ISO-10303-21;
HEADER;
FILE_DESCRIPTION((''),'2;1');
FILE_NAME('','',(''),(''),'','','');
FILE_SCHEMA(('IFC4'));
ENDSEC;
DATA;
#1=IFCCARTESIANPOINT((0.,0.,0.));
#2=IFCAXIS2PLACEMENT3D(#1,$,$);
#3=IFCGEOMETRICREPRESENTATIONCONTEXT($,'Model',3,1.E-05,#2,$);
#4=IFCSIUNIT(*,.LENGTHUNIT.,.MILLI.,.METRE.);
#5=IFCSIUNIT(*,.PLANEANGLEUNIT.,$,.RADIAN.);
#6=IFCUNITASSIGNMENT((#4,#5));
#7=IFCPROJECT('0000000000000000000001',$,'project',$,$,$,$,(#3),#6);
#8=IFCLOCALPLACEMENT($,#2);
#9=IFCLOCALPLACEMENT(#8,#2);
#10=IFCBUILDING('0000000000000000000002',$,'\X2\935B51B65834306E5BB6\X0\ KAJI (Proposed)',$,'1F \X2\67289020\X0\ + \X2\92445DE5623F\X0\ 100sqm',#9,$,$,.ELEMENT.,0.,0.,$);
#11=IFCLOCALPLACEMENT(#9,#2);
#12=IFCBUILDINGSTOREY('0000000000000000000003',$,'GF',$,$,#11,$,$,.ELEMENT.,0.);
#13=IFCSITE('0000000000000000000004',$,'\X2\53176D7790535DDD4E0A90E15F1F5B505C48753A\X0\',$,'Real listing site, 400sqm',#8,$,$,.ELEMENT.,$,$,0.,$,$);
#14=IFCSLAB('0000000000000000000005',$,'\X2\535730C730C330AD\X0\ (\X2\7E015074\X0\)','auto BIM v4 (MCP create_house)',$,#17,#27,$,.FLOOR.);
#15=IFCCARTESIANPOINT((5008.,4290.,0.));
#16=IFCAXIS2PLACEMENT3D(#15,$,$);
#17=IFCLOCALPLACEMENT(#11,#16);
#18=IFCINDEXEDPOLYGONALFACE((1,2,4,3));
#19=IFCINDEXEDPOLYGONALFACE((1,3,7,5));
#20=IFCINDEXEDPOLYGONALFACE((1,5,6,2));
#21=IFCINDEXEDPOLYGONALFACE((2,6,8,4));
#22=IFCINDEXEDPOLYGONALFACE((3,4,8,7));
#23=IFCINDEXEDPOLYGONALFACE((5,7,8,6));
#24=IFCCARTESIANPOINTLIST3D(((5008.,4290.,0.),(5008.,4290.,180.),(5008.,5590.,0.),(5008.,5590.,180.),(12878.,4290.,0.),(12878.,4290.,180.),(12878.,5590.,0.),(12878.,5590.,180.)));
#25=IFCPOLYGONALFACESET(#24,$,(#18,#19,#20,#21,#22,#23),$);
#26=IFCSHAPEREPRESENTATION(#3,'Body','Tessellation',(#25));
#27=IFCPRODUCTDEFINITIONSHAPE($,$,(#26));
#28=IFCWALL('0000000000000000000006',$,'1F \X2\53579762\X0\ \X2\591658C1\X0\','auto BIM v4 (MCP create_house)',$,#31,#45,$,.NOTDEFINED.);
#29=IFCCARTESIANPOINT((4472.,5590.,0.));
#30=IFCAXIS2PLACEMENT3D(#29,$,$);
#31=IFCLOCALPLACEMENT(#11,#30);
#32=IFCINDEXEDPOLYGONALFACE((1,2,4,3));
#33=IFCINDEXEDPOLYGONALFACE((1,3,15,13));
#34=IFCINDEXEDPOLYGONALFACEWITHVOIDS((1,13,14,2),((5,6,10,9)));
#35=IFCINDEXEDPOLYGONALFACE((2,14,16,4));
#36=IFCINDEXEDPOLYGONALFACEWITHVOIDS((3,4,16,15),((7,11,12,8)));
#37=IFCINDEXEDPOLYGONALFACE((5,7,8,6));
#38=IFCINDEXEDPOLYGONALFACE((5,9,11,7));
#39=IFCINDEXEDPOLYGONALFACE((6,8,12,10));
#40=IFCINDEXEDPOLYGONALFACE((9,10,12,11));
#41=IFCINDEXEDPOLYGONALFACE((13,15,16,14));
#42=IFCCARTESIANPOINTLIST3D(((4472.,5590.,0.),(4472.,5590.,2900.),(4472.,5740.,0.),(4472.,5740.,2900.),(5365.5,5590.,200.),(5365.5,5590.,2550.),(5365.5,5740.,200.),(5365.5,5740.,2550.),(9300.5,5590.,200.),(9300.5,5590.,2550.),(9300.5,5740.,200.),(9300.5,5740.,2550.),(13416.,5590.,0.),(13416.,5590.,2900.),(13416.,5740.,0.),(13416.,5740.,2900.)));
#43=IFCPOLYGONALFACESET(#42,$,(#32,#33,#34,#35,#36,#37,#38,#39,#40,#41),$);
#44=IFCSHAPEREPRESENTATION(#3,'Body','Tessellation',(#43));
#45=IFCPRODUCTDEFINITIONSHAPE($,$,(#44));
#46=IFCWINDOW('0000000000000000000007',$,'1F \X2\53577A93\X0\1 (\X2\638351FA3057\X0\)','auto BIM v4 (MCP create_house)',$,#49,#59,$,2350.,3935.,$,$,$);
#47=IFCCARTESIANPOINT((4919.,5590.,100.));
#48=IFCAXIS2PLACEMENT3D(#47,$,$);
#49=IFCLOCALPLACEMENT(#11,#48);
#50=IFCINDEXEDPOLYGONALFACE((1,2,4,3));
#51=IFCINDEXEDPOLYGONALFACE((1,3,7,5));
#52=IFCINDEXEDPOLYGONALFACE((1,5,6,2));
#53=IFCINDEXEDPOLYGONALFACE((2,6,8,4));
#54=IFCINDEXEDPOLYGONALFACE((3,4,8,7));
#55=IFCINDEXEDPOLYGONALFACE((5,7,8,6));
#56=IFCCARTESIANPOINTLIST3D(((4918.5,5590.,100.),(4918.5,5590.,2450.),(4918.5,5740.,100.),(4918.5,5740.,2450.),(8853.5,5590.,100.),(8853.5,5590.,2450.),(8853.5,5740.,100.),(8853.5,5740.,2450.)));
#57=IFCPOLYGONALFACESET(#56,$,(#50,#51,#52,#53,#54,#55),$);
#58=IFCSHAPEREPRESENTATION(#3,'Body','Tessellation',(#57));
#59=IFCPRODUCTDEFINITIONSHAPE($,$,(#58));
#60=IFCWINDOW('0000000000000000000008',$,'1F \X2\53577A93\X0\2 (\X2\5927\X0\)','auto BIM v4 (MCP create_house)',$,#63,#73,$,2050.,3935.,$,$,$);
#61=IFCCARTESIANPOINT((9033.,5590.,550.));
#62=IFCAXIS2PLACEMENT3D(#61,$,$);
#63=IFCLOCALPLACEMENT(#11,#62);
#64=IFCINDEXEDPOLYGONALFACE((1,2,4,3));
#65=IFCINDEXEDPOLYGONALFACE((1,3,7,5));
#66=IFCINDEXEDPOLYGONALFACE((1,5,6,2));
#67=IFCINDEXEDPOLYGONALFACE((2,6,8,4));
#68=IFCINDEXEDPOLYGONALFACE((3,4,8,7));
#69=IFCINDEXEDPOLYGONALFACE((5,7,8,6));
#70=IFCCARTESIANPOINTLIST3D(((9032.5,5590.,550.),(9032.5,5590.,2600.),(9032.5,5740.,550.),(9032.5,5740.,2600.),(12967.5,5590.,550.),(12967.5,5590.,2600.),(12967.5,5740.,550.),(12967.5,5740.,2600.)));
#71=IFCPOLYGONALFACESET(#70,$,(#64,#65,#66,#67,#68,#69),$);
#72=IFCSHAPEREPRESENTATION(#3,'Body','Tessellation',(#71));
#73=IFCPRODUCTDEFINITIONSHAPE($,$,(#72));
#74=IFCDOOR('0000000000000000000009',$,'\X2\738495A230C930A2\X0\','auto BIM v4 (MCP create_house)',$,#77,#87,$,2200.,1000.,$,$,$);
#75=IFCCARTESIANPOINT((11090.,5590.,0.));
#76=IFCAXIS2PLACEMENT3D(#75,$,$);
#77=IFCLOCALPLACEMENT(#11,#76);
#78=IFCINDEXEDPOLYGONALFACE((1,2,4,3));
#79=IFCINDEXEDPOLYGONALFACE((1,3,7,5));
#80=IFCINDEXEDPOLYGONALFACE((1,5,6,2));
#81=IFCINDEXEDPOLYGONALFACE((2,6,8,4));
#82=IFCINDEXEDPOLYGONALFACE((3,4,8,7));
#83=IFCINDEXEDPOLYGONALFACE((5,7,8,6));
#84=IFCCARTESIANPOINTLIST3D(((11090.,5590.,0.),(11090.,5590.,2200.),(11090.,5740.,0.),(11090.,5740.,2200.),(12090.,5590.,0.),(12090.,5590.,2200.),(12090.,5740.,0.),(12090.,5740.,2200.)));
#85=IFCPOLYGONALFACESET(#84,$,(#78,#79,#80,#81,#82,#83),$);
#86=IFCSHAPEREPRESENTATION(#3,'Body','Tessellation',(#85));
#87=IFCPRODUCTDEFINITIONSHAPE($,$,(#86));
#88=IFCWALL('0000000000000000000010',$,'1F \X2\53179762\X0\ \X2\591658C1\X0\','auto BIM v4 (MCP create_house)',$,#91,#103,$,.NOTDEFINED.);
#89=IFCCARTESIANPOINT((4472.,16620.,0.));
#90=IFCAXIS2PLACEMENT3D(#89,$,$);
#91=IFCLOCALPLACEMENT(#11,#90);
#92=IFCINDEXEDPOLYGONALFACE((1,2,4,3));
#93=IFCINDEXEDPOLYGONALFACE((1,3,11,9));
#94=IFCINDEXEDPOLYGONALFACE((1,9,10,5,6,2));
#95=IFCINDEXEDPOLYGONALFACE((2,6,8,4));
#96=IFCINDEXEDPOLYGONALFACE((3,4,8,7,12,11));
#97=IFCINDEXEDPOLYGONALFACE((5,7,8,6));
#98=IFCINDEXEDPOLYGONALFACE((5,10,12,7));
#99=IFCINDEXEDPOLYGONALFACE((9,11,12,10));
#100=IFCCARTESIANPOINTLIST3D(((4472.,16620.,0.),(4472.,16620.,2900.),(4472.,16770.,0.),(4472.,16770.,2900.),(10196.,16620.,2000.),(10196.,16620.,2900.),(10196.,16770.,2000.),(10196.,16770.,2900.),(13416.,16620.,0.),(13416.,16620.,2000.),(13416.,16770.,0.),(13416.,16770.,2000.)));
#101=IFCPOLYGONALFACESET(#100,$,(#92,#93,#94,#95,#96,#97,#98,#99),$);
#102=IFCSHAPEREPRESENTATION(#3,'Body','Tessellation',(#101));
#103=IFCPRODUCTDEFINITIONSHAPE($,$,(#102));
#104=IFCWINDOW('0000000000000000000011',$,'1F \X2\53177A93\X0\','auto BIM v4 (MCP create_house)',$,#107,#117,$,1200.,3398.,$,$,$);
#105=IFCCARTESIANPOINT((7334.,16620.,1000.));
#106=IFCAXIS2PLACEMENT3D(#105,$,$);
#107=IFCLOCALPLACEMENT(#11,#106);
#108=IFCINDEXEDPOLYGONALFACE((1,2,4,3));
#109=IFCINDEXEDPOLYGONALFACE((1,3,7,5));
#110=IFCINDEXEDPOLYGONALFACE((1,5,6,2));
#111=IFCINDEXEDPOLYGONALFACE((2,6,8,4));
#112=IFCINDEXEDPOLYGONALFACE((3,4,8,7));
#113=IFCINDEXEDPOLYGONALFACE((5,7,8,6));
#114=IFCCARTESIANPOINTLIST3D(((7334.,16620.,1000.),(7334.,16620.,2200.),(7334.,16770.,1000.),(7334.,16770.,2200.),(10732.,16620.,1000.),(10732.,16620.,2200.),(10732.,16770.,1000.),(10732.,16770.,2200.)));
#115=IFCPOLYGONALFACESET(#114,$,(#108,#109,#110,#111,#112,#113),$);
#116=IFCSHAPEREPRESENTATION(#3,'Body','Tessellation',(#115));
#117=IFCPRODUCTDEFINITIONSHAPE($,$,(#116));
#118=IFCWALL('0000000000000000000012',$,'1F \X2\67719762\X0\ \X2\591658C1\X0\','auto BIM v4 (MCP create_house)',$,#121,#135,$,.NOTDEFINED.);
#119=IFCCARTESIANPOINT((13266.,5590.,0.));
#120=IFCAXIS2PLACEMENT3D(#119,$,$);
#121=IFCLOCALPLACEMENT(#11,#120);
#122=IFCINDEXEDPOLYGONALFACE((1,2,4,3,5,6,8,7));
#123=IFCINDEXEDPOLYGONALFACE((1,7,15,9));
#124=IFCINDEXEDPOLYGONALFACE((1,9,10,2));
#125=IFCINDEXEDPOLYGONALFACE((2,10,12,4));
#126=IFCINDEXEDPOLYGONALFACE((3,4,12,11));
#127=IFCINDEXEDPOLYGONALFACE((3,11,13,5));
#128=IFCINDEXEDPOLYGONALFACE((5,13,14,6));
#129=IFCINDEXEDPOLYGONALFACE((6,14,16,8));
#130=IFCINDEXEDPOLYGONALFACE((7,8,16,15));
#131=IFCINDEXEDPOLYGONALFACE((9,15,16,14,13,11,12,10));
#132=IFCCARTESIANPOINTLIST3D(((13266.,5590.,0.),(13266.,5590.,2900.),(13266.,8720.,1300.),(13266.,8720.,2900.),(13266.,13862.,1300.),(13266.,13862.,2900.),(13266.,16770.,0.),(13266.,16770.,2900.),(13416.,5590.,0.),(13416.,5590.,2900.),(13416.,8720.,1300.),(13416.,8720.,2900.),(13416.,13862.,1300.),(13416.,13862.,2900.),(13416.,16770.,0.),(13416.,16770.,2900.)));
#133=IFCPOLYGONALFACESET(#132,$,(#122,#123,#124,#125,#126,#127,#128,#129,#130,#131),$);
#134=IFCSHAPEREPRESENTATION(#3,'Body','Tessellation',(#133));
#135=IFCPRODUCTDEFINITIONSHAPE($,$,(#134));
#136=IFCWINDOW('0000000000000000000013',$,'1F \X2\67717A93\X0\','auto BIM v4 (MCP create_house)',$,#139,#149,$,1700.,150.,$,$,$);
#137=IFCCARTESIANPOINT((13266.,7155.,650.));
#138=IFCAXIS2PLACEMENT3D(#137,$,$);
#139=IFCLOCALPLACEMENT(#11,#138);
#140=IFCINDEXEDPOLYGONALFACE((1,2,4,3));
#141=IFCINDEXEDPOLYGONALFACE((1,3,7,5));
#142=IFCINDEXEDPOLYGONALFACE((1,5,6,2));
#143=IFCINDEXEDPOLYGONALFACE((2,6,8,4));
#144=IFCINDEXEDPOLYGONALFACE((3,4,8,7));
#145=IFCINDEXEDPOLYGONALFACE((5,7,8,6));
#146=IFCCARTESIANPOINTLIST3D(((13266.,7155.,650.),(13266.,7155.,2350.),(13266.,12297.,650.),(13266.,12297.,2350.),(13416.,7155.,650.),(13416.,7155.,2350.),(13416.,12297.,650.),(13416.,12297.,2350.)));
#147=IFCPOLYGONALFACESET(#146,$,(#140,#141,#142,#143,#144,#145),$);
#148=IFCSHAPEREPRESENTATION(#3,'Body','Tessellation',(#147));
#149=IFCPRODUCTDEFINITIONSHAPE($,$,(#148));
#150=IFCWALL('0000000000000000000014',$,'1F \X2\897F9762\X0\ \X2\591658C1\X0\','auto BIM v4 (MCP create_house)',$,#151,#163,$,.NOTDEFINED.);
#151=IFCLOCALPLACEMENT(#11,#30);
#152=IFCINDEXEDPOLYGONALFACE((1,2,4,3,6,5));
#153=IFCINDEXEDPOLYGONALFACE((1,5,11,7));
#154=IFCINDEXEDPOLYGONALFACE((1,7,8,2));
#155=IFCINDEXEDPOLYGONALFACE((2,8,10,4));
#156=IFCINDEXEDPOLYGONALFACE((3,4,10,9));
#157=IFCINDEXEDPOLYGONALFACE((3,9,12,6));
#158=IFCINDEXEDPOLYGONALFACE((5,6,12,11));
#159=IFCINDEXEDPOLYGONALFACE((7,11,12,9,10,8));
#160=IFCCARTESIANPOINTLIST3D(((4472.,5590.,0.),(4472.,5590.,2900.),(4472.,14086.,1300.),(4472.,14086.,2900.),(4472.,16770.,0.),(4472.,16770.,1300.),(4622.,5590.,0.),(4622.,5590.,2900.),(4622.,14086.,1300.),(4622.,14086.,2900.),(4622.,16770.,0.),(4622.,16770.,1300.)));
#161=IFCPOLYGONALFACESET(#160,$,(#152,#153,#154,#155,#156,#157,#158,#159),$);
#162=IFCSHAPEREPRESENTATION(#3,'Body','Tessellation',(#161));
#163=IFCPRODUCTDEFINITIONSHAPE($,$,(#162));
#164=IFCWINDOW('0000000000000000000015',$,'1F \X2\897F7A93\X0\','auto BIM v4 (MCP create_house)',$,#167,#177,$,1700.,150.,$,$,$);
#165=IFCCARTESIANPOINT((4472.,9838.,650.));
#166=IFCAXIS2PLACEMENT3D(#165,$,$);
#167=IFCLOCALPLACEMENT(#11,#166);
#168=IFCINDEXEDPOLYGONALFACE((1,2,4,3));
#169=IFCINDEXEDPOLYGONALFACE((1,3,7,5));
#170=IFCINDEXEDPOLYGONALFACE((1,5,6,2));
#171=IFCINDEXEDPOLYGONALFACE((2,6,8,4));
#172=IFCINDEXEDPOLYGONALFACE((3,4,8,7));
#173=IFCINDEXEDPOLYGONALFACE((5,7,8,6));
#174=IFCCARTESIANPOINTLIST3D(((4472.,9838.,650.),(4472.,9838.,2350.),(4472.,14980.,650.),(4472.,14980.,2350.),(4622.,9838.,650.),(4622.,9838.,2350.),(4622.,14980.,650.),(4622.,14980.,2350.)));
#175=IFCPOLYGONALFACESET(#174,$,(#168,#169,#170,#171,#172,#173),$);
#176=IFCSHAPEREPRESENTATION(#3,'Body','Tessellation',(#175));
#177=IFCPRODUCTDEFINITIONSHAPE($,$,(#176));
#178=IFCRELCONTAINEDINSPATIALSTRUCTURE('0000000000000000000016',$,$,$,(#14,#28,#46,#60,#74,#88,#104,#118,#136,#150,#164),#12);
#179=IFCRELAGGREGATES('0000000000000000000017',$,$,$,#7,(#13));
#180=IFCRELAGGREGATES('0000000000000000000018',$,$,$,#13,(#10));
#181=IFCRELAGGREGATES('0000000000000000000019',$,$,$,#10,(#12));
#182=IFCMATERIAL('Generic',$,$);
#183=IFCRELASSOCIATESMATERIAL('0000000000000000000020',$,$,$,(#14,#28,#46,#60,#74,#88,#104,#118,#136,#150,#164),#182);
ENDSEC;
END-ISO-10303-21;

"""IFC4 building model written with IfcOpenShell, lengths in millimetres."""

from ifc_helpers import new_model, si_unit, frame, frame_2d, origin, place, context, project, spatial, rectangle, extrude, material, element, fill, save


model = new_model("IFC4")

# Units and contexts
model_context = context("Model", 3, precision=1e-05, world=origin())
ifc_project = project(units=[si_unit("LENGTHUNIT", "METRE", prefix="MILLI"), si_unit("PLANEANGLEUNIT", "RADIAN")], contexts=[model_context])

# Site, building, storey
site_placement = place(None, origin())
site = spatial("IfcSite", under=ifc_project, at=site_placement, Name="北海道川上郡弟子屈町", ObjectType="Real listing site, 400sqm", CompositionType="ELEMENT", RefElevation=0.0)
building_placement = place(site_placement, origin())
building = spatial("IfcBuilding", under=site, at=building_placement, Name="鍛冶場の家 KAJI (Proposed)", ObjectType="1F 木造 + 鉄工房 100sqm", CompositionType="ELEMENT", ElevationOfRefHeight=0.0, ElevationOfTerrain=0.0)
storey_placement = place(building_placement, origin())
storey = spatial("IfcBuildingStorey", under=building, at=storey_placement, Name="GF", CompositionType="ELEMENT", Elevation=0.0)

# Slab
ifc_material = material(Name="Generic")
slab_1_placement = place(storey_placement, frame((5008.0, 4290.0, 0.0)))
element("IfcSlab", 1, at=slab_1_placement, inside=storey, material=ifc_material, Name="南デッキ (縁側)", Description="auto BIM v4 (MCP create_house)", PredefinedType="FLOOR", context=model_context, shape_type="SweptSolid", body=[
    extrude(rectangle(XDim=7870.0, YDim=1300.0, at=frame_2d((3935.0, 650.0))), frame((5008.0, 4290.0, 0.0)), (0.0, 0.0, 1.0), 180.0),
])

# Wall, openings, windows, door
wall_1_placement = place(storey_placement, frame((4472.0, 5590.0, 0.0)))
wall_1 = element("IfcWall", 2, at=wall_1_placement, inside=storey, material=ifc_material, Name="1F 南面 外壁", Description="auto BIM v4 (MCP create_house)", PredefinedType="NOTDEFINED", context=model_context, shape_type="SweptSolid", body=[
    extrude(rectangle(XDim=8944.0, YDim=150.0, at=frame_2d((4472.0, 75.0))), frame((4472.0, 5590.0, 0.0)), (0.0, 0.0, 1.0), 2900.0),
])
opening_1_placement = place(storey_placement, frame((4919.0, 5590.0, 100.0)))
opening_1 = element("IfcOpeningElement", 3, at=opening_1_placement, cuts=wall_1, PredefinedType="NOTDEFINED", context=model_context, shape_type="SweptSolid", body=[
    extrude(rectangle(XDim=3935.0, YDim=150.0, at=frame_2d((1967.0, 75.0))), frame((4919.0, 5590.0, 100.0)), (0.0, 0.0, 1.0), 2350.0),
])
opening_2_placement = place(storey_placement, frame((9033.0, 5590.0, 550.0)))
opening_2 = element("IfcOpeningElement", 4, at=opening_2_placement, cuts=wall_1, PredefinedType="NOTDEFINED", context=model_context, shape_type="SweptSolid", body=[
    extrude(rectangle(XDim=3935.0, YDim=150.0, at=frame_2d((1967.0, 75.0))), frame((9033.0, 5590.0, 550.0)), (0.0, 0.0, 1.0), 2050.0),
])
opening_3_placement = place(storey_placement, frame((11090.0, 5590.0, 0.0)))
opening_3 = element("IfcOpeningElement", 5, at=opening_3_placement, cuts=wall_1, PredefinedType="NOTDEFINED", context=model_context, shape_type="SweptSolid", body=[
    extrude(rectangle(XDim=1000.0, YDim=150.0, at=frame_2d((500.0, 75.0))), frame((11090.0, 5590.0, 0.0)), (0.0, 0.0, 1.0), 2200.0),
])
window_1_placement = place(storey_placement, frame((4919.0, 5590.0, 100.0)))
window_1 = element("IfcWindow", 6, at=window_1_placement, inside=storey, material=ifc_material, Name="1F 南窓1 (掃出し)", Description="auto BIM v4 (MCP create_house)", OverallHeight=2350.0, OverallWidth=3935.0, context=model_context, shape_type="SweptSolid", body=[
    extrude(rectangle(XDim=3935.0, YDim=150.0, at=frame_2d((1967.0, 75.0))), frame((4919.0, 5590.0, 100.0)), (0.0, 0.0, 1.0), 2350.0),
])
fill(opening_1, window_1)
window_2_placement = place(storey_placement, frame((9033.0, 5590.0, 550.0)))
window_2 = element("IfcWindow", 7, at=window_2_placement, inside=storey, material=ifc_material, Name="1F 南窓2 (大)", Description="auto BIM v4 (MCP create_house)", OverallHeight=2050.0, OverallWidth=3935.0, context=model_context, shape_type="SweptSolid", body=[
    extrude(rectangle(XDim=3935.0, YDim=150.0, at=frame_2d((1967.0, 75.0))), frame((9033.0, 5590.0, 550.0)), (0.0, 0.0, 1.0), 2050.0),
])
fill(opening_2, window_2)
door_placement = place(storey_placement, frame((11090.0, 5590.0, 0.0)))
door = element("IfcDoor", 8, at=door_placement, inside=storey, material=ifc_material, Name="玄関ドア", Description="auto BIM v4 (MCP create_house)", OverallHeight=2200.0, OverallWidth=1000.0, context=model_context, shape_type="SweptSolid", body=[
    extrude(rectangle(XDim=1000.0, YDim=150.0, at=frame_2d((500.0, 75.0))), frame((11090.0, 5590.0, 0.0)), (0.0, 0.0, 1.0), 2200.0),
])
fill(opening_3, door)

# Walls, openings, windows
wall_2_placement = place(storey_placement, frame((4472.0, 16620.0, 0.0)))
wall_2 = element("IfcWall", 9, at=wall_2_placement, inside=storey, material=ifc_material, Name="1F 北面 外壁", Description="auto BIM v4 (MCP create_house)", PredefinedType="NOTDEFINED", context=model_context, shape_type="SweptSolid", body=[
    extrude(rectangle(XDim=8944.0, YDim=150.0, at=frame_2d((4472.0, 75.0))), frame((4472.0, 16620.0, 0.0)), (0.0, 0.0, 1.0), 2900.0),
])
opening_4_placement = place(storey_placement, frame((7334.0, 16620.0, 1000.0)))
opening_4 = element("IfcOpeningElement", 10, at=opening_4_placement, cuts=wall_2, PredefinedType="NOTDEFINED", context=model_context, shape_type="SweptSolid", body=[
    extrude(rectangle(XDim=3398.0, YDim=150.0, at=frame_2d((1699.0, 75.0))), frame((7334.0, 16620.0, 1000.0)), (0.0, 0.0, 1.0), 1200.0),
])
window_3_placement = place(storey_placement, frame((7334.0, 16620.0, 1000.0)))
window_3 = element("IfcWindow", 11, at=window_3_placement, inside=storey, material=ifc_material, Name="1F 北窓", Description="auto BIM v4 (MCP create_house)", OverallHeight=1200.0, OverallWidth=3398.0, context=model_context, shape_type="SweptSolid", body=[
    extrude(rectangle(XDim=3398.0, YDim=150.0, at=frame_2d((1699.0, 75.0))), frame((7334.0, 16620.0, 1000.0)), (0.0, 0.0, 1.0), 1200.0),
])
fill(opening_4, window_3)
wall_3_placement = place(storey_placement, frame((13266.0, 5590.0, 0.0)))
wall_3 = element("IfcWall", 12, at=wall_3_placement, inside=storey, material=ifc_material, Name="1F 東面 外壁", Description="auto BIM v4 (MCP create_house)", PredefinedType="NOTDEFINED", context=model_context, shape_type="SweptSolid", body=[
    extrude(rectangle(XDim=150.0, YDim=11180.0, at=frame_2d((75.0, 5590.0))), frame((13266.0, 5590.0, 0.0)), (0.0, 0.0, 1.0), 2900.0),
])
opening_5_placement = place(storey_placement, frame((13266.0, 7155.0, 650.0)))
opening_5 = element("IfcOpeningElement", 13, at=opening_5_placement, cuts=wall_3, PredefinedType="NOTDEFINED", context=model_context, shape_type="SweptSolid", body=[
    extrude(rectangle(XDim=150.0, YDim=5142.0, at=frame_2d((75.0, 2571.0))), frame((13266.0, 7155.0, 650.0)), (0.0, 0.0, 1.0), 1700.0),
])
window_4_placement = place(storey_placement, frame((13266.0, 7155.0, 650.0)))
window_4 = element("IfcWindow", 14, at=window_4_placement, inside=storey, material=ifc_material, Name="1F 東窓", Description="auto BIM v4 (MCP create_house)", OverallHeight=1700.0, OverallWidth=150.0, context=model_context, shape_type="SweptSolid", body=[
    extrude(rectangle(XDim=150.0, YDim=5142.0, at=frame_2d((75.0, 2571.0))), frame((13266.0, 7155.0, 650.0)), (0.0, 0.0, 1.0), 1700.0),
])
fill(opening_5, window_4)
wall_4_placement = place(storey_placement, frame((4472.0, 5590.0, 0.0)))
wall_4 = element("IfcWall", 15, at=wall_4_placement, inside=storey, material=ifc_material, Name="1F 西面 外壁", Description="auto BIM v4 (MCP create_house)", PredefinedType="NOTDEFINED", context=model_context, shape_type="SweptSolid", body=[
    extrude(rectangle(XDim=150.0, YDim=11180.0, at=frame_2d((75.0, 5590.0))), frame((4472.0, 5590.0, 0.0)), (0.0, 0.0, 1.0), 2900.0),
])
opening_6_placement = place(storey_placement, frame((4472.0, 9838.0, 650.0)))
opening_6 = element("IfcOpeningElement", 16, at=opening_6_placement, cuts=wall_4, PredefinedType="NOTDEFINED", context=model_context, shape_type="SweptSolid", body=[
    extrude(rectangle(XDim=150.0, YDim=5142.0, at=frame_2d((75.0, 2571.0))), frame((4472.0, 9838.0, 650.0)), (0.0, 0.0, 1.0), 1700.0),
])
window_5_placement = place(storey_placement, frame((4472.0, 9838.0, 650.0)))
window_5 = element("IfcWindow", 17, at=window_5_placement, inside=storey, material=ifc_material, Name="1F 西窓", Description="auto BIM v4 (MCP create_house)", OverallHeight=1700.0, OverallWidth=150.0, context=model_context, shape_type="SweptSolid", body=[
    extrude(rectangle(XDim=150.0, YDim=5142.0, at=frame_2d((75.0, 2571.0))), frame((4472.0, 9838.0, 650.0)), (0.0, 0.0, 1.0), 1700.0),
])
fill(opening_6, window_5)

save(model, "model.ifc")
